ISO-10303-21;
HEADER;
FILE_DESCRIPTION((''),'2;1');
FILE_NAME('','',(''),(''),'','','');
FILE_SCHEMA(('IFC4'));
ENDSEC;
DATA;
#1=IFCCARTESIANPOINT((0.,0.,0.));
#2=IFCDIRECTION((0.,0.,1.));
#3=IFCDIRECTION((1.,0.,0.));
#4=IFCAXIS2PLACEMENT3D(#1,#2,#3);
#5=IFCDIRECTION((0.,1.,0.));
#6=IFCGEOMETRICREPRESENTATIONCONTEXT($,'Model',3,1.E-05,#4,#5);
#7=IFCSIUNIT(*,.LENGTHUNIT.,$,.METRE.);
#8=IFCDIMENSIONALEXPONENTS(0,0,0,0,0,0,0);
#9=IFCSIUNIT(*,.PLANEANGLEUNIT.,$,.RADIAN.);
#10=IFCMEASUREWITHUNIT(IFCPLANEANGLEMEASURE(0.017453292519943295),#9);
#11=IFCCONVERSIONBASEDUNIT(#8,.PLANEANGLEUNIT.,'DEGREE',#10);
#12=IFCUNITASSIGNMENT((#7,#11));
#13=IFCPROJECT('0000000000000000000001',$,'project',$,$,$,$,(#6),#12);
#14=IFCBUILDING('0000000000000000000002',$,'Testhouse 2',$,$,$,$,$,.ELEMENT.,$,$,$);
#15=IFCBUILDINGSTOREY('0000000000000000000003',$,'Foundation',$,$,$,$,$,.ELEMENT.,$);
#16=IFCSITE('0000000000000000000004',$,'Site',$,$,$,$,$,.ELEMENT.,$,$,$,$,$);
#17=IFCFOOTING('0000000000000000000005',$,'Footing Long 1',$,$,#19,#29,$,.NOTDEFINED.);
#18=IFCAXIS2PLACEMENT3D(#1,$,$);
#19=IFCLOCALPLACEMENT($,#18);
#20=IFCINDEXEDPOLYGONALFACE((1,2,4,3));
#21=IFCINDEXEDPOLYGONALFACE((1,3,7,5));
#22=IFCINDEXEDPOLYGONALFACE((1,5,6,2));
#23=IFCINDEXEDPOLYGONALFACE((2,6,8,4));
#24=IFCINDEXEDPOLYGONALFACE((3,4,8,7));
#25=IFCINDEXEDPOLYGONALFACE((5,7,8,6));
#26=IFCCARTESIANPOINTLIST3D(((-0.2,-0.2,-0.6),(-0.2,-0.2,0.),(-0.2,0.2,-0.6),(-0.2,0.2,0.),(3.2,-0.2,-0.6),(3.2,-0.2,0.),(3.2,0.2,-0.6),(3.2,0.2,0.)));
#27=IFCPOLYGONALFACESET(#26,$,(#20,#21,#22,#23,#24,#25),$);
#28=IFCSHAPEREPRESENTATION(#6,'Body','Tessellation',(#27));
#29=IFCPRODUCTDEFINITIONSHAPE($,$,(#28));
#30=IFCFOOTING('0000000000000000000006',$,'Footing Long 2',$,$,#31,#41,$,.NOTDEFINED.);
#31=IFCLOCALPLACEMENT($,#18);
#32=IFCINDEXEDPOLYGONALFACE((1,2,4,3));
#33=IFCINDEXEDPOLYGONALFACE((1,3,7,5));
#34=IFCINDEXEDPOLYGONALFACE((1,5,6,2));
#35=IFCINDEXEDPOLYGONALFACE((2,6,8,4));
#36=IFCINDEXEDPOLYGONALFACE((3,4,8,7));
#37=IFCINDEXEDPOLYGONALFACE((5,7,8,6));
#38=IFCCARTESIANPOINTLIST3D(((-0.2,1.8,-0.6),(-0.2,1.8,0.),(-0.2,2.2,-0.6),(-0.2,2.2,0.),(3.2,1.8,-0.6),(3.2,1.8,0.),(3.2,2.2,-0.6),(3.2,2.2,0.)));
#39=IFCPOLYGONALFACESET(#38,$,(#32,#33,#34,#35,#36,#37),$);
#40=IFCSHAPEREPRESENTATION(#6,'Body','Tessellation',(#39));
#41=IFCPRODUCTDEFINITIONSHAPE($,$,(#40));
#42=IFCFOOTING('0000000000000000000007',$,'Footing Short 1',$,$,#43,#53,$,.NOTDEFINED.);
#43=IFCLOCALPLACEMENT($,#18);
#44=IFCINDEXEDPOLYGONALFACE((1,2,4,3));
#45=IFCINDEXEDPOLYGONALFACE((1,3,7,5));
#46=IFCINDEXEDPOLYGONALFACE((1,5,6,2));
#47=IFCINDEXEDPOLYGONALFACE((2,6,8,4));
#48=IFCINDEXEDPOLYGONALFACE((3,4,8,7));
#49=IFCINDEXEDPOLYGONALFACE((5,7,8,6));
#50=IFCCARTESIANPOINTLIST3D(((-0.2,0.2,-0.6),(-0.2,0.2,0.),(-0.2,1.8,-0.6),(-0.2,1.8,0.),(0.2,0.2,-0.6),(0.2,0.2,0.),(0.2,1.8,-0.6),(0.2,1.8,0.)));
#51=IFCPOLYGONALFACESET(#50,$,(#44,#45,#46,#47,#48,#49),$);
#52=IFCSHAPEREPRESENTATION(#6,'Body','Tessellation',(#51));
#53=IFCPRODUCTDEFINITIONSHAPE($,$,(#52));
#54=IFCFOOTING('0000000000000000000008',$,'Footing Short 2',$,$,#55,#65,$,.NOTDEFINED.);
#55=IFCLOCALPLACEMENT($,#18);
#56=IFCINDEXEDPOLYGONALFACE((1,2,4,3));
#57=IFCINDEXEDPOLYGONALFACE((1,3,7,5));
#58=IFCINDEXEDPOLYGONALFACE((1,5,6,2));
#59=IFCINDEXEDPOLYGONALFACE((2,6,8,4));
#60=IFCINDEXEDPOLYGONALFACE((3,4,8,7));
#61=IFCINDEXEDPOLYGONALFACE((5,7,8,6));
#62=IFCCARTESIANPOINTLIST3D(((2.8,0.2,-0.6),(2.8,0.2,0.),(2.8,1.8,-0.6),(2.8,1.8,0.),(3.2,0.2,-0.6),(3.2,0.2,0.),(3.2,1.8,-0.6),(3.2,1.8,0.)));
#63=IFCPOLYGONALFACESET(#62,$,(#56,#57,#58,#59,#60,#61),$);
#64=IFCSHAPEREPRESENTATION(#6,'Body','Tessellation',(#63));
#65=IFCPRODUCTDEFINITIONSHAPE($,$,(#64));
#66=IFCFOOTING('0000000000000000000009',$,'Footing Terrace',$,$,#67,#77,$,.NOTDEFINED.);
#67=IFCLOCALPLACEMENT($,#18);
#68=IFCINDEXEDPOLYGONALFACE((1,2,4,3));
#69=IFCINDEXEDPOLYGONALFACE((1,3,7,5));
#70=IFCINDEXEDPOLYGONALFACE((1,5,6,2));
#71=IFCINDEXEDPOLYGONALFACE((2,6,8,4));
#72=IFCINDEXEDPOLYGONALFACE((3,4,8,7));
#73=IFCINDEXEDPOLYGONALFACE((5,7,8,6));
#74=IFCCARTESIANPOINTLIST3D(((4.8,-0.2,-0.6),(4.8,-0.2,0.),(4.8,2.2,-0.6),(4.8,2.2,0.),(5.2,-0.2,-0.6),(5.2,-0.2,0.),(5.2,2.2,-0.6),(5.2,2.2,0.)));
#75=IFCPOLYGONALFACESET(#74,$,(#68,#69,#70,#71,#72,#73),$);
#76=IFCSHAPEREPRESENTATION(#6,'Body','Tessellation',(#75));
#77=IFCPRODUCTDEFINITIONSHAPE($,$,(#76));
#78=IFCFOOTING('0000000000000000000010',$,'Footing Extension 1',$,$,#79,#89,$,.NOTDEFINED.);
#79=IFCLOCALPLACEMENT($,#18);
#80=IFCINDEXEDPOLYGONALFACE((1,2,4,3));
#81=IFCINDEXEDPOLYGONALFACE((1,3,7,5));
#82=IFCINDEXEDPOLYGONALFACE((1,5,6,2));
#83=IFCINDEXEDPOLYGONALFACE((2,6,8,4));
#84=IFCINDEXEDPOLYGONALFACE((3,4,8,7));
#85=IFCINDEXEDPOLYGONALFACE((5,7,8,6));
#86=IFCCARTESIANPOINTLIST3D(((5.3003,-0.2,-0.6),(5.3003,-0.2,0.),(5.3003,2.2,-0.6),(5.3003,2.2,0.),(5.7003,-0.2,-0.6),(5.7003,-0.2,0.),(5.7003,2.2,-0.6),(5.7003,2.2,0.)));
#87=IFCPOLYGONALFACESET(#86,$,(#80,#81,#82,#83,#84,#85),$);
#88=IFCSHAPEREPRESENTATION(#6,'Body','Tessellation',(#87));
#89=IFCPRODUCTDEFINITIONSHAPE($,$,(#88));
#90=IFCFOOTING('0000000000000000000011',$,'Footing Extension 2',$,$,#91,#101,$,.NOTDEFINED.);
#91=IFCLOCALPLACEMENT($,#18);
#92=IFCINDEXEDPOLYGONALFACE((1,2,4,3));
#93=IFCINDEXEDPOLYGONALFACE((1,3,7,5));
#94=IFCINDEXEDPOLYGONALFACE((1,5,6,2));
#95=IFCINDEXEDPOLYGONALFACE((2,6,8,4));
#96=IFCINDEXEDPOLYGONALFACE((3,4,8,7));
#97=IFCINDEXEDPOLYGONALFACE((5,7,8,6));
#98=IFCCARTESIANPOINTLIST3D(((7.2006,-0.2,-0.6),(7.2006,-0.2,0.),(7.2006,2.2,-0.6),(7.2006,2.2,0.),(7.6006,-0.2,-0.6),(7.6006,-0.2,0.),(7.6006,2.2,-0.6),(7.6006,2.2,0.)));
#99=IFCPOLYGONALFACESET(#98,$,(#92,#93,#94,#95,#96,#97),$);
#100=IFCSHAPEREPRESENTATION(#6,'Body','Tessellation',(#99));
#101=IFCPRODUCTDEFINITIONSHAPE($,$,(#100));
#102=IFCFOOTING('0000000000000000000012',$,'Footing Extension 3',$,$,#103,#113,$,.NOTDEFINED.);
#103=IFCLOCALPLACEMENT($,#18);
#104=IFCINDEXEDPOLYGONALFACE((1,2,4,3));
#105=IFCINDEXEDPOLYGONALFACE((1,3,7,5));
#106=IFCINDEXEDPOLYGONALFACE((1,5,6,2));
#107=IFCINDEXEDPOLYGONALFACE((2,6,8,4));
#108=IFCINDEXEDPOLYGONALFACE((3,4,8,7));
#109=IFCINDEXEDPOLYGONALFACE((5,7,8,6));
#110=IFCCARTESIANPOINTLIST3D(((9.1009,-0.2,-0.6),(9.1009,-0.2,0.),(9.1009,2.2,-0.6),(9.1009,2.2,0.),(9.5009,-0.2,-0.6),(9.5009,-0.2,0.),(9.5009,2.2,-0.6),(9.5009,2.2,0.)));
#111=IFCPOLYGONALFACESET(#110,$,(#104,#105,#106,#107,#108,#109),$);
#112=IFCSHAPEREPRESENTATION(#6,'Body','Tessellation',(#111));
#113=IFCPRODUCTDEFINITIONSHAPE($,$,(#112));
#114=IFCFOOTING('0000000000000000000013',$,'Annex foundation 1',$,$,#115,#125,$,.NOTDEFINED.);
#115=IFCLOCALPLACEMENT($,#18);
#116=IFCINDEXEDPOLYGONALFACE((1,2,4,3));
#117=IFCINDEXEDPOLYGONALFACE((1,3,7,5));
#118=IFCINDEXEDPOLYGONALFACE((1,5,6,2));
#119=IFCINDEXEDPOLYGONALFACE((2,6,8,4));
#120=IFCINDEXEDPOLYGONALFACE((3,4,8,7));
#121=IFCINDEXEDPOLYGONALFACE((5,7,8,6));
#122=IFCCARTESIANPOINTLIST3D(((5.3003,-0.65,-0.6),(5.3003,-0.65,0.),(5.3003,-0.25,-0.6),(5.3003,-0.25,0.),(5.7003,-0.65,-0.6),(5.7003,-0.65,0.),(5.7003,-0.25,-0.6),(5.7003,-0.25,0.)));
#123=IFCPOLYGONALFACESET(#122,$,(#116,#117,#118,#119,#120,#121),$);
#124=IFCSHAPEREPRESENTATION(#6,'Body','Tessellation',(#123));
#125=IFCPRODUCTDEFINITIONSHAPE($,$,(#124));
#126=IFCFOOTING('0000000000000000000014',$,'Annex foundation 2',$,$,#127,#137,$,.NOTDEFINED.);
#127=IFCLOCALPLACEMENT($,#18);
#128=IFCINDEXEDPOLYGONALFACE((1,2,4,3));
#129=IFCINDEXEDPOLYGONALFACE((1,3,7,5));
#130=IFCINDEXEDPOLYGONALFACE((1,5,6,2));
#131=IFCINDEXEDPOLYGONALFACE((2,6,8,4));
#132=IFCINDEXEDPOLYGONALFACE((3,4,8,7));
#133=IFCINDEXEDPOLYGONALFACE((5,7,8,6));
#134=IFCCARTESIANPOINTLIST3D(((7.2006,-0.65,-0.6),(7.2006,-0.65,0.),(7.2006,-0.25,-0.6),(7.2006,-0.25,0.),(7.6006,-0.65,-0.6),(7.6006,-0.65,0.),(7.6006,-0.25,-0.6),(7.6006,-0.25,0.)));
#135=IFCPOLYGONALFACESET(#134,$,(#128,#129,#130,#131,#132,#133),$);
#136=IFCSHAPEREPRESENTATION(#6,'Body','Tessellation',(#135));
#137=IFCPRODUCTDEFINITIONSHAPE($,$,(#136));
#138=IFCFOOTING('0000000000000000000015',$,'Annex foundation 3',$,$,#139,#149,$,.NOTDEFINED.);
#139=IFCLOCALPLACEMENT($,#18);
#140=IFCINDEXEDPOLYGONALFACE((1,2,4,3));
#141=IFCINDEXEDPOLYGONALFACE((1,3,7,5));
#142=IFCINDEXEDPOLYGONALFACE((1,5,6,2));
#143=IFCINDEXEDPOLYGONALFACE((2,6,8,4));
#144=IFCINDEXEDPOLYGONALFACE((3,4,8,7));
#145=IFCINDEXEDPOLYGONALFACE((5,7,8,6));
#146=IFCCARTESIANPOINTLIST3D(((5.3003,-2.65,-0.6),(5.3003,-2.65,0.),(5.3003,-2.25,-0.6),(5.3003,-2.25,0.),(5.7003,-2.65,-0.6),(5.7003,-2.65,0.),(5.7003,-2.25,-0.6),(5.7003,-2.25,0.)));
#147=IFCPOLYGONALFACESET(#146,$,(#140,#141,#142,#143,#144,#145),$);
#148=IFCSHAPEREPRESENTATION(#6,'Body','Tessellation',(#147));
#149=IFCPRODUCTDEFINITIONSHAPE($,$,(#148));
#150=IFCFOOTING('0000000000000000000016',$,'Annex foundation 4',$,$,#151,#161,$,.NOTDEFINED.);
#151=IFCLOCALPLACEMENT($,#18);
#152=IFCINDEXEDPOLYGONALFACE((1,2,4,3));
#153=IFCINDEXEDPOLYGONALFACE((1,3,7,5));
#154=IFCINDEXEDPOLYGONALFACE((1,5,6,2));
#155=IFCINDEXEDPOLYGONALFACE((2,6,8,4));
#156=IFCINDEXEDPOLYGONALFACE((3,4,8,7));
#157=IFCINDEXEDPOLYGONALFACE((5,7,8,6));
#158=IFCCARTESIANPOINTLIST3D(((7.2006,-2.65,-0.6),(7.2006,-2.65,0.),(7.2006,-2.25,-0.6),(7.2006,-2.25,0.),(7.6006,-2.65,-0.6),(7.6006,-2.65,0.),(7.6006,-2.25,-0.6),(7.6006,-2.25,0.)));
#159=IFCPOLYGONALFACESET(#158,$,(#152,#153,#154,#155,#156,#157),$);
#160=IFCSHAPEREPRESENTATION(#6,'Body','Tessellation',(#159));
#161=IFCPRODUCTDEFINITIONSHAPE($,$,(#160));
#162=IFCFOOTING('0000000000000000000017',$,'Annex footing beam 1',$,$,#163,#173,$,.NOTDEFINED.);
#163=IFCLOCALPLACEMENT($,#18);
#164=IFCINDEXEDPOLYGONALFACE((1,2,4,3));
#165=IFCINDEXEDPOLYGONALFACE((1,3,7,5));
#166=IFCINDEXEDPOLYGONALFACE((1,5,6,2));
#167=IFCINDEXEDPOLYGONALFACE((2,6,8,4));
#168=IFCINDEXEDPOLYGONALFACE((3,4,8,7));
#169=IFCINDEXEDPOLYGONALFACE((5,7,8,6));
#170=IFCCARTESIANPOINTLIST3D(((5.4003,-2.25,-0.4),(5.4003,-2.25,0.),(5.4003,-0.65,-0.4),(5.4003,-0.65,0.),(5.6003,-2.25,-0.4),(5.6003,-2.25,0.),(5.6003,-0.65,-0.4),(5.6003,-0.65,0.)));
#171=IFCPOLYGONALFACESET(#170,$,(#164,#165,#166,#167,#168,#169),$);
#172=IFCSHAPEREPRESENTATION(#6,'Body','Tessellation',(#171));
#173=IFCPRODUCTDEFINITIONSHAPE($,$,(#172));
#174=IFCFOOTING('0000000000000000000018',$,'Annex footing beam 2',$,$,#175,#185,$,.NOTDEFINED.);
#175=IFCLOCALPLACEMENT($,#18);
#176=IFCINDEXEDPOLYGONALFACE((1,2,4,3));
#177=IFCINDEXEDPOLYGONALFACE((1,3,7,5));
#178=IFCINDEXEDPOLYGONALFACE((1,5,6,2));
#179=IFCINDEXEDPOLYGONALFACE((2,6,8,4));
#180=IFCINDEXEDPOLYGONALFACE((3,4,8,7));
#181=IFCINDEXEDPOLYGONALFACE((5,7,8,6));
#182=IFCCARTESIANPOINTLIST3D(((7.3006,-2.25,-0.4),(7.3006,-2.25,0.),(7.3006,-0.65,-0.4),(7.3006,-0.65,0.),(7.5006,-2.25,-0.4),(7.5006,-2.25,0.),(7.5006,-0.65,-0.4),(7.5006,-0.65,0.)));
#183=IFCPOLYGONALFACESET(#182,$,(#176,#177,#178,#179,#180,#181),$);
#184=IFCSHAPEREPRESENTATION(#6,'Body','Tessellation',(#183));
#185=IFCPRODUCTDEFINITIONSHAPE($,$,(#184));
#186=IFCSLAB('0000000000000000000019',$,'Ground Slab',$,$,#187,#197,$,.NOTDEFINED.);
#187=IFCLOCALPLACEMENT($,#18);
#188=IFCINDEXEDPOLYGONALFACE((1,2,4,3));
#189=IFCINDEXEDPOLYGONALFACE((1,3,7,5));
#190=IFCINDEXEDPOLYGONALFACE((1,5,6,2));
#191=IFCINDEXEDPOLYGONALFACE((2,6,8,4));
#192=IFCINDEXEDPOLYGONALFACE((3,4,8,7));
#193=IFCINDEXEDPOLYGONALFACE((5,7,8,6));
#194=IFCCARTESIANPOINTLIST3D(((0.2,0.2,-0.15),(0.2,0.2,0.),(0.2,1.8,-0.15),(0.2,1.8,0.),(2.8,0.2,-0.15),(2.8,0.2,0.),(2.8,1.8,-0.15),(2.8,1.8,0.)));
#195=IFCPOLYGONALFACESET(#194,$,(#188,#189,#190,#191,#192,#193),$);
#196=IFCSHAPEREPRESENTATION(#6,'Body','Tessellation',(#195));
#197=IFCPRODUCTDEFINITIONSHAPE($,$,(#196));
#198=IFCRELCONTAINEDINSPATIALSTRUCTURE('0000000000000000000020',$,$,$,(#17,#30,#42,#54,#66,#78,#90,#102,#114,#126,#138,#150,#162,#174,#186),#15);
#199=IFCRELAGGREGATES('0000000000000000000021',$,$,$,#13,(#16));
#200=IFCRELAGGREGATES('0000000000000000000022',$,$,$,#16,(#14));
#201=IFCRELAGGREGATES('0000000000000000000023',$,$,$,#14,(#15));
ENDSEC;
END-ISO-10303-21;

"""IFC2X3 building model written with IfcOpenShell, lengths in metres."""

from ifc_helpers import new_model, entity, si_unit, converted_unit, direction, frame, origin_with_axes, place, context, project, spatial, polyline, outline, extrude, element, save


model = new_model("IFC2X3")

# Units and contexts
model_context = context("Model", 3, precision=1e-05, world=origin_with_axes(), true_north=direction((0.0, 1.0, 0.0)))
ifc_project = project(units=[si_unit("LENGTHUNIT", "METRE"), converted_unit("PLANEANGLEUNIT", "DEGREE", entity("IfcPlaneAngleMeasure", 0.017453292519943295), si_unit("PLANEANGLEUNIT", "RADIAN"), dimensions=[0, 0, 0, 0, 0, 0, 0])], contexts=[model_context])

# Site, building, storey
site = spatial("IfcSite", under=ifc_project, Name="Site", CompositionType="ELEMENT")
building = spatial("IfcBuilding", under=site, Name="Testhouse 2", CompositionType="ELEMENT")
storey = spatial("IfcBuildingStorey", under=building, Name="Foundation", CompositionType="ELEMENT")

# Footings
footing_1_placement = place(None, origin_with_axes())
element("IfcFooting", 1, at=footing_1_placement, inside=storey, Name="Footing Long 1", PredefinedType="NOTDEFINED", context=model_context, shape_type="SweptSolid", body=[
    extrude(outline(polyline([(-0.3, -0.2), (0.3, -0.2), (0.3, 0.2), (-0.3, 0.2), (-0.3, -0.2)])), frame((-0.2, 0.0, -0.3), z_axis=(1.0, 0.0, 0.0), x_axis=(0.0, 0.0, -1.0)), (0.0, 0.0, 1.0), 3.4),
])
footing_2_placement = place(None, origin_with_axes())
element("IfcFooting", 2, at=footing_2_placement, inside=storey, Name="Footing Long 2", PredefinedType="NOTDEFINED", context=model_context, shape_type="SweptSolid", body=[
    extrude(outline(polyline([(-0.3, -0.2), (0.3, -0.2), (0.3, 0.2), (-0.3, 0.2), (-0.3, -0.2)])), frame((-0.2, 2.0, -0.3), z_axis=(1.0, 0.0, 0.0), x_axis=(0.0, 0.0, -1.0)), (0.0, 0.0, 1.0), 3.4),
])
footing_3_placement = place(None, origin_with_axes())
element("IfcFooting", 3, at=footing_3_placement, inside=storey, Name="Footing Short 1", PredefinedType="NOTDEFINED", context=model_context, shape_type="SweptSolid", body=[
    extrude(outline(polyline([(-0.3, -0.2), (0.3, -0.2), (0.3, 0.2), (-0.3, 0.2), (-0.3, -0.2)])), frame((0.0, 0.2, -0.3), z_axis=(0.0, 1.0, 0.0), x_axis=(0.0, 0.0, -1.0)), (0.0, 0.0, 1.0), 1.6),
])
footing_4_placement = place(None, origin_with_axes())
element("IfcFooting", 4, at=footing_4_placement, inside=storey, Name="Footing Short 2", PredefinedType="NOTDEFINED", context=model_context, shape_type="SweptSolid", body=[
    extrude(outline(polyline([(-0.3, -0.2), (0.3, -0.2), (0.3, 0.2), (-0.3, 0.2), (-0.3, -0.2)])), frame((3.0, 0.2, -0.3), z_axis=(0.0, 1.0, 0.0), x_axis=(0.0, 0.0, -1.0)), (0.0, 0.0, 1.0), 1.6),
])
footing_5_placement = place(None, origin_with_axes())
element("IfcFooting", 5, at=footing_5_placement, inside=storey, Name="Footing Terrace", PredefinedType="NOTDEFINED", context=model_context, shape_type="SweptSolid", body=[
    extrude(outline(polyline([(-0.3, -0.2), (0.3, -0.2), (0.3, 0.2), (-0.3, 0.2), (-0.3, -0.2)])), frame((5.0, -0.2, -0.3), z_axis=(0.0, 1.0, 0.0), x_axis=(0.0, 0.0, -1.0)), (0.0, 0.0, 1.0), 2.4),
])
footing_6_placement = place(None, origin_with_axes())
element("IfcFooting", 6, at=footing_6_placement, inside=storey, Name="Footing Extension 1", PredefinedType="NOTDEFINED", context=model_context, shape_type="SweptSolid", body=[
    extrude(outline(polyline([(-0.3, -0.2), (0.3, -0.2), (0.3, 0.2), (-0.3, 0.2), (-0.3, -0.2)])), frame((5.5003, -0.2, -0.3), z_axis=(0.0, 1.0, 0.0), x_axis=(0.0, 0.0, -1.0)), (0.0, 0.0, 1.0), 2.4),
])
footing_7_placement = place(None, origin_with_axes())
element("IfcFooting", 7, at=footing_7_placement, inside=storey, Name="Footing Extension 2", PredefinedType="NOTDEFINED", context=model_context, shape_type="SweptSolid", body=[
    extrude(outline(polyline([(-0.3, -0.2), (0.3, -0.2), (0.3, 0.2), (-0.3, 0.2), (-0.3, -0.2)])), frame((7.4006, -0.2, -0.3), z_axis=(0.0, 1.0, 0.0), x_axis=(0.0, 0.0, -1.0)), (0.0, 0.0, 1.0), 2.4),
])
footing_8_placement = place(None, origin_with_axes())
element("IfcFooting", 8, at=footing_8_placement, inside=storey, Name="Footing Extension 3", PredefinedType="NOTDEFINED", context=model_context, shape_type="SweptSolid", body=[
    extrude(outline(polyline([(-0.3, -0.2), (0.3, -0.2), (0.3, 0.2), (-0.3, 0.2), (-0.3, -0.2)])), frame((9.3009, -0.2, -0.3), z_axis=(0.0, 1.0, 0.0), x_axis=(0.0, 0.0, -1.0)), (0.0, 0.0, 1.0), 2.4),
])
footing_9_placement = place(None, origin_with_axes())
element("IfcFooting", 9, at=footing_9_placement, inside=storey, Name="Annex foundation 1", PredefinedType="NOTDEFINED", context=model_context, shape_type="SweptSolid", body=[
    extrude(outline(polyline([(-0.2, -0.2), (0.2, -0.2), (0.2, 0.2), (-0.2, 0.2), (-0.2, -0.2)])), frame((5.5003, -0.45, -0.6), z_axis=(0.0, 0.0, 1.0), x_axis=(1.0, 0.0, 0.0)), (0.0, 0.0, 1.0), 0.6),
])
footing_10_placement = place(None, origin_with_axes())
element("IfcFooting", 10, at=footing_10_placement, inside=storey, Name="Annex foundation 2", PredefinedType="NOTDEFINED", context=model_context, shape_type="SweptSolid", body=[
    extrude(outline(polyline([(-0.2, -0.2), (0.2, -0.2), (0.2, 0.2), (-0.2, 0.2), (-0.2, -0.2)])), frame((7.4006, -0.45, -0.6), z_axis=(0.0, 0.0, 1.0), x_axis=(1.0, 0.0, 0.0)), (0.0, 0.0, 1.0), 0.6),
])
footing_11_placement = place(None, origin_with_axes())
element("IfcFooting", 11, at=footing_11_placement, inside=storey, Name="Annex foundation 3", PredefinedType="NOTDEFINED", context=model_context, shape_type="SweptSolid", body=[
    extrude(outline(polyline([(-0.2, -0.2), (0.2, -0.2), (0.2, 0.2), (-0.2, 0.2), (-0.2, -0.2)])), frame((5.5003, -2.45, -0.6), z_axis=(0.0, 0.0, 1.0), x_axis=(1.0, 0.0, 0.0)), (0.0, 0.0, 1.0), 0.6),
])
footing_12_placement = place(None, origin_with_axes())
element("IfcFooting", 12, at=footing_12_placement, inside=storey, Name="Annex foundation 4", PredefinedType="NOTDEFINED", context=model_context, shape_type="SweptSolid", body=[
    extrude(outline(polyline([(-0.2, -0.2), (0.2, -0.2), (0.2, 0.2), (-0.2, 0.2), (-0.2, -0.2)])), frame((7.4006, -2.45, -0.6), z_axis=(0.0, 0.0, 1.0), x_axis=(1.0, 0.0, 0.0)), (0.0, 0.0, 1.0), 0.6),
])
footing_13_placement = place(None, origin_with_axes())
element("IfcFooting", 13, at=footing_13_placement, inside=storey, Name="Annex footing beam 1", PredefinedType="NOTDEFINED", context=model_context, shape_type="SweptSolid", body=[
    extrude(outline(polyline([(-0.2, -0.1), (0.2, -0.1), (0.2, 0.1), (-0.2, 0.1), (-0.2, -0.1)])), frame((5.5003, -2.25, -0.2), z_axis=(0.0, 1.0, 0.0), x_axis=(0.0, 0.0, -1.0)), (0.0, 0.0, 1.0), 1.6),
])
footing_14_placement = place(None, origin_with_axes())
element("IfcFooting", 14, at=footing_14_placement, inside=storey, Name="Annex footing beam 2", PredefinedType="NOTDEFINED", context=model_context, shape_type="SweptSolid", body=[
    extrude(outline(polyline([(-0.2, -0.1), (0.2, -0.1), (0.2, 0.1), (-0.2, 0.1), (-0.2, -0.1)])), frame((7.4006, -2.25, -0.2), z_axis=(0.0, 1.0, 0.0), x_axis=(0.0, 0.0, -1.0)), (0.0, 0.0, 1.0), 1.6),
])

# Slab
slab_1_placement = place(None, origin_with_axes())
element("IfcSlab", 15, at=slab_1_placement, inside=storey, Name="Ground Slab", PredefinedType="NOTDEFINED", context=model_context, shape_type="SweptSolid", body=[
    extrude(outline(polyline([(0.0, 0.0), (2.6, 0.0), (2.6, -1.6), (0.0, -1.6), (0.0, 0.0)])), frame((0.2, 1.8, -0.15), z_axis=(0.0, 0.0, 1.0), x_axis=(1.0, 0.0, 0.0)), (0.0, 0.0, 1.0), 0.15),
])

save(model, "model.ifc")
